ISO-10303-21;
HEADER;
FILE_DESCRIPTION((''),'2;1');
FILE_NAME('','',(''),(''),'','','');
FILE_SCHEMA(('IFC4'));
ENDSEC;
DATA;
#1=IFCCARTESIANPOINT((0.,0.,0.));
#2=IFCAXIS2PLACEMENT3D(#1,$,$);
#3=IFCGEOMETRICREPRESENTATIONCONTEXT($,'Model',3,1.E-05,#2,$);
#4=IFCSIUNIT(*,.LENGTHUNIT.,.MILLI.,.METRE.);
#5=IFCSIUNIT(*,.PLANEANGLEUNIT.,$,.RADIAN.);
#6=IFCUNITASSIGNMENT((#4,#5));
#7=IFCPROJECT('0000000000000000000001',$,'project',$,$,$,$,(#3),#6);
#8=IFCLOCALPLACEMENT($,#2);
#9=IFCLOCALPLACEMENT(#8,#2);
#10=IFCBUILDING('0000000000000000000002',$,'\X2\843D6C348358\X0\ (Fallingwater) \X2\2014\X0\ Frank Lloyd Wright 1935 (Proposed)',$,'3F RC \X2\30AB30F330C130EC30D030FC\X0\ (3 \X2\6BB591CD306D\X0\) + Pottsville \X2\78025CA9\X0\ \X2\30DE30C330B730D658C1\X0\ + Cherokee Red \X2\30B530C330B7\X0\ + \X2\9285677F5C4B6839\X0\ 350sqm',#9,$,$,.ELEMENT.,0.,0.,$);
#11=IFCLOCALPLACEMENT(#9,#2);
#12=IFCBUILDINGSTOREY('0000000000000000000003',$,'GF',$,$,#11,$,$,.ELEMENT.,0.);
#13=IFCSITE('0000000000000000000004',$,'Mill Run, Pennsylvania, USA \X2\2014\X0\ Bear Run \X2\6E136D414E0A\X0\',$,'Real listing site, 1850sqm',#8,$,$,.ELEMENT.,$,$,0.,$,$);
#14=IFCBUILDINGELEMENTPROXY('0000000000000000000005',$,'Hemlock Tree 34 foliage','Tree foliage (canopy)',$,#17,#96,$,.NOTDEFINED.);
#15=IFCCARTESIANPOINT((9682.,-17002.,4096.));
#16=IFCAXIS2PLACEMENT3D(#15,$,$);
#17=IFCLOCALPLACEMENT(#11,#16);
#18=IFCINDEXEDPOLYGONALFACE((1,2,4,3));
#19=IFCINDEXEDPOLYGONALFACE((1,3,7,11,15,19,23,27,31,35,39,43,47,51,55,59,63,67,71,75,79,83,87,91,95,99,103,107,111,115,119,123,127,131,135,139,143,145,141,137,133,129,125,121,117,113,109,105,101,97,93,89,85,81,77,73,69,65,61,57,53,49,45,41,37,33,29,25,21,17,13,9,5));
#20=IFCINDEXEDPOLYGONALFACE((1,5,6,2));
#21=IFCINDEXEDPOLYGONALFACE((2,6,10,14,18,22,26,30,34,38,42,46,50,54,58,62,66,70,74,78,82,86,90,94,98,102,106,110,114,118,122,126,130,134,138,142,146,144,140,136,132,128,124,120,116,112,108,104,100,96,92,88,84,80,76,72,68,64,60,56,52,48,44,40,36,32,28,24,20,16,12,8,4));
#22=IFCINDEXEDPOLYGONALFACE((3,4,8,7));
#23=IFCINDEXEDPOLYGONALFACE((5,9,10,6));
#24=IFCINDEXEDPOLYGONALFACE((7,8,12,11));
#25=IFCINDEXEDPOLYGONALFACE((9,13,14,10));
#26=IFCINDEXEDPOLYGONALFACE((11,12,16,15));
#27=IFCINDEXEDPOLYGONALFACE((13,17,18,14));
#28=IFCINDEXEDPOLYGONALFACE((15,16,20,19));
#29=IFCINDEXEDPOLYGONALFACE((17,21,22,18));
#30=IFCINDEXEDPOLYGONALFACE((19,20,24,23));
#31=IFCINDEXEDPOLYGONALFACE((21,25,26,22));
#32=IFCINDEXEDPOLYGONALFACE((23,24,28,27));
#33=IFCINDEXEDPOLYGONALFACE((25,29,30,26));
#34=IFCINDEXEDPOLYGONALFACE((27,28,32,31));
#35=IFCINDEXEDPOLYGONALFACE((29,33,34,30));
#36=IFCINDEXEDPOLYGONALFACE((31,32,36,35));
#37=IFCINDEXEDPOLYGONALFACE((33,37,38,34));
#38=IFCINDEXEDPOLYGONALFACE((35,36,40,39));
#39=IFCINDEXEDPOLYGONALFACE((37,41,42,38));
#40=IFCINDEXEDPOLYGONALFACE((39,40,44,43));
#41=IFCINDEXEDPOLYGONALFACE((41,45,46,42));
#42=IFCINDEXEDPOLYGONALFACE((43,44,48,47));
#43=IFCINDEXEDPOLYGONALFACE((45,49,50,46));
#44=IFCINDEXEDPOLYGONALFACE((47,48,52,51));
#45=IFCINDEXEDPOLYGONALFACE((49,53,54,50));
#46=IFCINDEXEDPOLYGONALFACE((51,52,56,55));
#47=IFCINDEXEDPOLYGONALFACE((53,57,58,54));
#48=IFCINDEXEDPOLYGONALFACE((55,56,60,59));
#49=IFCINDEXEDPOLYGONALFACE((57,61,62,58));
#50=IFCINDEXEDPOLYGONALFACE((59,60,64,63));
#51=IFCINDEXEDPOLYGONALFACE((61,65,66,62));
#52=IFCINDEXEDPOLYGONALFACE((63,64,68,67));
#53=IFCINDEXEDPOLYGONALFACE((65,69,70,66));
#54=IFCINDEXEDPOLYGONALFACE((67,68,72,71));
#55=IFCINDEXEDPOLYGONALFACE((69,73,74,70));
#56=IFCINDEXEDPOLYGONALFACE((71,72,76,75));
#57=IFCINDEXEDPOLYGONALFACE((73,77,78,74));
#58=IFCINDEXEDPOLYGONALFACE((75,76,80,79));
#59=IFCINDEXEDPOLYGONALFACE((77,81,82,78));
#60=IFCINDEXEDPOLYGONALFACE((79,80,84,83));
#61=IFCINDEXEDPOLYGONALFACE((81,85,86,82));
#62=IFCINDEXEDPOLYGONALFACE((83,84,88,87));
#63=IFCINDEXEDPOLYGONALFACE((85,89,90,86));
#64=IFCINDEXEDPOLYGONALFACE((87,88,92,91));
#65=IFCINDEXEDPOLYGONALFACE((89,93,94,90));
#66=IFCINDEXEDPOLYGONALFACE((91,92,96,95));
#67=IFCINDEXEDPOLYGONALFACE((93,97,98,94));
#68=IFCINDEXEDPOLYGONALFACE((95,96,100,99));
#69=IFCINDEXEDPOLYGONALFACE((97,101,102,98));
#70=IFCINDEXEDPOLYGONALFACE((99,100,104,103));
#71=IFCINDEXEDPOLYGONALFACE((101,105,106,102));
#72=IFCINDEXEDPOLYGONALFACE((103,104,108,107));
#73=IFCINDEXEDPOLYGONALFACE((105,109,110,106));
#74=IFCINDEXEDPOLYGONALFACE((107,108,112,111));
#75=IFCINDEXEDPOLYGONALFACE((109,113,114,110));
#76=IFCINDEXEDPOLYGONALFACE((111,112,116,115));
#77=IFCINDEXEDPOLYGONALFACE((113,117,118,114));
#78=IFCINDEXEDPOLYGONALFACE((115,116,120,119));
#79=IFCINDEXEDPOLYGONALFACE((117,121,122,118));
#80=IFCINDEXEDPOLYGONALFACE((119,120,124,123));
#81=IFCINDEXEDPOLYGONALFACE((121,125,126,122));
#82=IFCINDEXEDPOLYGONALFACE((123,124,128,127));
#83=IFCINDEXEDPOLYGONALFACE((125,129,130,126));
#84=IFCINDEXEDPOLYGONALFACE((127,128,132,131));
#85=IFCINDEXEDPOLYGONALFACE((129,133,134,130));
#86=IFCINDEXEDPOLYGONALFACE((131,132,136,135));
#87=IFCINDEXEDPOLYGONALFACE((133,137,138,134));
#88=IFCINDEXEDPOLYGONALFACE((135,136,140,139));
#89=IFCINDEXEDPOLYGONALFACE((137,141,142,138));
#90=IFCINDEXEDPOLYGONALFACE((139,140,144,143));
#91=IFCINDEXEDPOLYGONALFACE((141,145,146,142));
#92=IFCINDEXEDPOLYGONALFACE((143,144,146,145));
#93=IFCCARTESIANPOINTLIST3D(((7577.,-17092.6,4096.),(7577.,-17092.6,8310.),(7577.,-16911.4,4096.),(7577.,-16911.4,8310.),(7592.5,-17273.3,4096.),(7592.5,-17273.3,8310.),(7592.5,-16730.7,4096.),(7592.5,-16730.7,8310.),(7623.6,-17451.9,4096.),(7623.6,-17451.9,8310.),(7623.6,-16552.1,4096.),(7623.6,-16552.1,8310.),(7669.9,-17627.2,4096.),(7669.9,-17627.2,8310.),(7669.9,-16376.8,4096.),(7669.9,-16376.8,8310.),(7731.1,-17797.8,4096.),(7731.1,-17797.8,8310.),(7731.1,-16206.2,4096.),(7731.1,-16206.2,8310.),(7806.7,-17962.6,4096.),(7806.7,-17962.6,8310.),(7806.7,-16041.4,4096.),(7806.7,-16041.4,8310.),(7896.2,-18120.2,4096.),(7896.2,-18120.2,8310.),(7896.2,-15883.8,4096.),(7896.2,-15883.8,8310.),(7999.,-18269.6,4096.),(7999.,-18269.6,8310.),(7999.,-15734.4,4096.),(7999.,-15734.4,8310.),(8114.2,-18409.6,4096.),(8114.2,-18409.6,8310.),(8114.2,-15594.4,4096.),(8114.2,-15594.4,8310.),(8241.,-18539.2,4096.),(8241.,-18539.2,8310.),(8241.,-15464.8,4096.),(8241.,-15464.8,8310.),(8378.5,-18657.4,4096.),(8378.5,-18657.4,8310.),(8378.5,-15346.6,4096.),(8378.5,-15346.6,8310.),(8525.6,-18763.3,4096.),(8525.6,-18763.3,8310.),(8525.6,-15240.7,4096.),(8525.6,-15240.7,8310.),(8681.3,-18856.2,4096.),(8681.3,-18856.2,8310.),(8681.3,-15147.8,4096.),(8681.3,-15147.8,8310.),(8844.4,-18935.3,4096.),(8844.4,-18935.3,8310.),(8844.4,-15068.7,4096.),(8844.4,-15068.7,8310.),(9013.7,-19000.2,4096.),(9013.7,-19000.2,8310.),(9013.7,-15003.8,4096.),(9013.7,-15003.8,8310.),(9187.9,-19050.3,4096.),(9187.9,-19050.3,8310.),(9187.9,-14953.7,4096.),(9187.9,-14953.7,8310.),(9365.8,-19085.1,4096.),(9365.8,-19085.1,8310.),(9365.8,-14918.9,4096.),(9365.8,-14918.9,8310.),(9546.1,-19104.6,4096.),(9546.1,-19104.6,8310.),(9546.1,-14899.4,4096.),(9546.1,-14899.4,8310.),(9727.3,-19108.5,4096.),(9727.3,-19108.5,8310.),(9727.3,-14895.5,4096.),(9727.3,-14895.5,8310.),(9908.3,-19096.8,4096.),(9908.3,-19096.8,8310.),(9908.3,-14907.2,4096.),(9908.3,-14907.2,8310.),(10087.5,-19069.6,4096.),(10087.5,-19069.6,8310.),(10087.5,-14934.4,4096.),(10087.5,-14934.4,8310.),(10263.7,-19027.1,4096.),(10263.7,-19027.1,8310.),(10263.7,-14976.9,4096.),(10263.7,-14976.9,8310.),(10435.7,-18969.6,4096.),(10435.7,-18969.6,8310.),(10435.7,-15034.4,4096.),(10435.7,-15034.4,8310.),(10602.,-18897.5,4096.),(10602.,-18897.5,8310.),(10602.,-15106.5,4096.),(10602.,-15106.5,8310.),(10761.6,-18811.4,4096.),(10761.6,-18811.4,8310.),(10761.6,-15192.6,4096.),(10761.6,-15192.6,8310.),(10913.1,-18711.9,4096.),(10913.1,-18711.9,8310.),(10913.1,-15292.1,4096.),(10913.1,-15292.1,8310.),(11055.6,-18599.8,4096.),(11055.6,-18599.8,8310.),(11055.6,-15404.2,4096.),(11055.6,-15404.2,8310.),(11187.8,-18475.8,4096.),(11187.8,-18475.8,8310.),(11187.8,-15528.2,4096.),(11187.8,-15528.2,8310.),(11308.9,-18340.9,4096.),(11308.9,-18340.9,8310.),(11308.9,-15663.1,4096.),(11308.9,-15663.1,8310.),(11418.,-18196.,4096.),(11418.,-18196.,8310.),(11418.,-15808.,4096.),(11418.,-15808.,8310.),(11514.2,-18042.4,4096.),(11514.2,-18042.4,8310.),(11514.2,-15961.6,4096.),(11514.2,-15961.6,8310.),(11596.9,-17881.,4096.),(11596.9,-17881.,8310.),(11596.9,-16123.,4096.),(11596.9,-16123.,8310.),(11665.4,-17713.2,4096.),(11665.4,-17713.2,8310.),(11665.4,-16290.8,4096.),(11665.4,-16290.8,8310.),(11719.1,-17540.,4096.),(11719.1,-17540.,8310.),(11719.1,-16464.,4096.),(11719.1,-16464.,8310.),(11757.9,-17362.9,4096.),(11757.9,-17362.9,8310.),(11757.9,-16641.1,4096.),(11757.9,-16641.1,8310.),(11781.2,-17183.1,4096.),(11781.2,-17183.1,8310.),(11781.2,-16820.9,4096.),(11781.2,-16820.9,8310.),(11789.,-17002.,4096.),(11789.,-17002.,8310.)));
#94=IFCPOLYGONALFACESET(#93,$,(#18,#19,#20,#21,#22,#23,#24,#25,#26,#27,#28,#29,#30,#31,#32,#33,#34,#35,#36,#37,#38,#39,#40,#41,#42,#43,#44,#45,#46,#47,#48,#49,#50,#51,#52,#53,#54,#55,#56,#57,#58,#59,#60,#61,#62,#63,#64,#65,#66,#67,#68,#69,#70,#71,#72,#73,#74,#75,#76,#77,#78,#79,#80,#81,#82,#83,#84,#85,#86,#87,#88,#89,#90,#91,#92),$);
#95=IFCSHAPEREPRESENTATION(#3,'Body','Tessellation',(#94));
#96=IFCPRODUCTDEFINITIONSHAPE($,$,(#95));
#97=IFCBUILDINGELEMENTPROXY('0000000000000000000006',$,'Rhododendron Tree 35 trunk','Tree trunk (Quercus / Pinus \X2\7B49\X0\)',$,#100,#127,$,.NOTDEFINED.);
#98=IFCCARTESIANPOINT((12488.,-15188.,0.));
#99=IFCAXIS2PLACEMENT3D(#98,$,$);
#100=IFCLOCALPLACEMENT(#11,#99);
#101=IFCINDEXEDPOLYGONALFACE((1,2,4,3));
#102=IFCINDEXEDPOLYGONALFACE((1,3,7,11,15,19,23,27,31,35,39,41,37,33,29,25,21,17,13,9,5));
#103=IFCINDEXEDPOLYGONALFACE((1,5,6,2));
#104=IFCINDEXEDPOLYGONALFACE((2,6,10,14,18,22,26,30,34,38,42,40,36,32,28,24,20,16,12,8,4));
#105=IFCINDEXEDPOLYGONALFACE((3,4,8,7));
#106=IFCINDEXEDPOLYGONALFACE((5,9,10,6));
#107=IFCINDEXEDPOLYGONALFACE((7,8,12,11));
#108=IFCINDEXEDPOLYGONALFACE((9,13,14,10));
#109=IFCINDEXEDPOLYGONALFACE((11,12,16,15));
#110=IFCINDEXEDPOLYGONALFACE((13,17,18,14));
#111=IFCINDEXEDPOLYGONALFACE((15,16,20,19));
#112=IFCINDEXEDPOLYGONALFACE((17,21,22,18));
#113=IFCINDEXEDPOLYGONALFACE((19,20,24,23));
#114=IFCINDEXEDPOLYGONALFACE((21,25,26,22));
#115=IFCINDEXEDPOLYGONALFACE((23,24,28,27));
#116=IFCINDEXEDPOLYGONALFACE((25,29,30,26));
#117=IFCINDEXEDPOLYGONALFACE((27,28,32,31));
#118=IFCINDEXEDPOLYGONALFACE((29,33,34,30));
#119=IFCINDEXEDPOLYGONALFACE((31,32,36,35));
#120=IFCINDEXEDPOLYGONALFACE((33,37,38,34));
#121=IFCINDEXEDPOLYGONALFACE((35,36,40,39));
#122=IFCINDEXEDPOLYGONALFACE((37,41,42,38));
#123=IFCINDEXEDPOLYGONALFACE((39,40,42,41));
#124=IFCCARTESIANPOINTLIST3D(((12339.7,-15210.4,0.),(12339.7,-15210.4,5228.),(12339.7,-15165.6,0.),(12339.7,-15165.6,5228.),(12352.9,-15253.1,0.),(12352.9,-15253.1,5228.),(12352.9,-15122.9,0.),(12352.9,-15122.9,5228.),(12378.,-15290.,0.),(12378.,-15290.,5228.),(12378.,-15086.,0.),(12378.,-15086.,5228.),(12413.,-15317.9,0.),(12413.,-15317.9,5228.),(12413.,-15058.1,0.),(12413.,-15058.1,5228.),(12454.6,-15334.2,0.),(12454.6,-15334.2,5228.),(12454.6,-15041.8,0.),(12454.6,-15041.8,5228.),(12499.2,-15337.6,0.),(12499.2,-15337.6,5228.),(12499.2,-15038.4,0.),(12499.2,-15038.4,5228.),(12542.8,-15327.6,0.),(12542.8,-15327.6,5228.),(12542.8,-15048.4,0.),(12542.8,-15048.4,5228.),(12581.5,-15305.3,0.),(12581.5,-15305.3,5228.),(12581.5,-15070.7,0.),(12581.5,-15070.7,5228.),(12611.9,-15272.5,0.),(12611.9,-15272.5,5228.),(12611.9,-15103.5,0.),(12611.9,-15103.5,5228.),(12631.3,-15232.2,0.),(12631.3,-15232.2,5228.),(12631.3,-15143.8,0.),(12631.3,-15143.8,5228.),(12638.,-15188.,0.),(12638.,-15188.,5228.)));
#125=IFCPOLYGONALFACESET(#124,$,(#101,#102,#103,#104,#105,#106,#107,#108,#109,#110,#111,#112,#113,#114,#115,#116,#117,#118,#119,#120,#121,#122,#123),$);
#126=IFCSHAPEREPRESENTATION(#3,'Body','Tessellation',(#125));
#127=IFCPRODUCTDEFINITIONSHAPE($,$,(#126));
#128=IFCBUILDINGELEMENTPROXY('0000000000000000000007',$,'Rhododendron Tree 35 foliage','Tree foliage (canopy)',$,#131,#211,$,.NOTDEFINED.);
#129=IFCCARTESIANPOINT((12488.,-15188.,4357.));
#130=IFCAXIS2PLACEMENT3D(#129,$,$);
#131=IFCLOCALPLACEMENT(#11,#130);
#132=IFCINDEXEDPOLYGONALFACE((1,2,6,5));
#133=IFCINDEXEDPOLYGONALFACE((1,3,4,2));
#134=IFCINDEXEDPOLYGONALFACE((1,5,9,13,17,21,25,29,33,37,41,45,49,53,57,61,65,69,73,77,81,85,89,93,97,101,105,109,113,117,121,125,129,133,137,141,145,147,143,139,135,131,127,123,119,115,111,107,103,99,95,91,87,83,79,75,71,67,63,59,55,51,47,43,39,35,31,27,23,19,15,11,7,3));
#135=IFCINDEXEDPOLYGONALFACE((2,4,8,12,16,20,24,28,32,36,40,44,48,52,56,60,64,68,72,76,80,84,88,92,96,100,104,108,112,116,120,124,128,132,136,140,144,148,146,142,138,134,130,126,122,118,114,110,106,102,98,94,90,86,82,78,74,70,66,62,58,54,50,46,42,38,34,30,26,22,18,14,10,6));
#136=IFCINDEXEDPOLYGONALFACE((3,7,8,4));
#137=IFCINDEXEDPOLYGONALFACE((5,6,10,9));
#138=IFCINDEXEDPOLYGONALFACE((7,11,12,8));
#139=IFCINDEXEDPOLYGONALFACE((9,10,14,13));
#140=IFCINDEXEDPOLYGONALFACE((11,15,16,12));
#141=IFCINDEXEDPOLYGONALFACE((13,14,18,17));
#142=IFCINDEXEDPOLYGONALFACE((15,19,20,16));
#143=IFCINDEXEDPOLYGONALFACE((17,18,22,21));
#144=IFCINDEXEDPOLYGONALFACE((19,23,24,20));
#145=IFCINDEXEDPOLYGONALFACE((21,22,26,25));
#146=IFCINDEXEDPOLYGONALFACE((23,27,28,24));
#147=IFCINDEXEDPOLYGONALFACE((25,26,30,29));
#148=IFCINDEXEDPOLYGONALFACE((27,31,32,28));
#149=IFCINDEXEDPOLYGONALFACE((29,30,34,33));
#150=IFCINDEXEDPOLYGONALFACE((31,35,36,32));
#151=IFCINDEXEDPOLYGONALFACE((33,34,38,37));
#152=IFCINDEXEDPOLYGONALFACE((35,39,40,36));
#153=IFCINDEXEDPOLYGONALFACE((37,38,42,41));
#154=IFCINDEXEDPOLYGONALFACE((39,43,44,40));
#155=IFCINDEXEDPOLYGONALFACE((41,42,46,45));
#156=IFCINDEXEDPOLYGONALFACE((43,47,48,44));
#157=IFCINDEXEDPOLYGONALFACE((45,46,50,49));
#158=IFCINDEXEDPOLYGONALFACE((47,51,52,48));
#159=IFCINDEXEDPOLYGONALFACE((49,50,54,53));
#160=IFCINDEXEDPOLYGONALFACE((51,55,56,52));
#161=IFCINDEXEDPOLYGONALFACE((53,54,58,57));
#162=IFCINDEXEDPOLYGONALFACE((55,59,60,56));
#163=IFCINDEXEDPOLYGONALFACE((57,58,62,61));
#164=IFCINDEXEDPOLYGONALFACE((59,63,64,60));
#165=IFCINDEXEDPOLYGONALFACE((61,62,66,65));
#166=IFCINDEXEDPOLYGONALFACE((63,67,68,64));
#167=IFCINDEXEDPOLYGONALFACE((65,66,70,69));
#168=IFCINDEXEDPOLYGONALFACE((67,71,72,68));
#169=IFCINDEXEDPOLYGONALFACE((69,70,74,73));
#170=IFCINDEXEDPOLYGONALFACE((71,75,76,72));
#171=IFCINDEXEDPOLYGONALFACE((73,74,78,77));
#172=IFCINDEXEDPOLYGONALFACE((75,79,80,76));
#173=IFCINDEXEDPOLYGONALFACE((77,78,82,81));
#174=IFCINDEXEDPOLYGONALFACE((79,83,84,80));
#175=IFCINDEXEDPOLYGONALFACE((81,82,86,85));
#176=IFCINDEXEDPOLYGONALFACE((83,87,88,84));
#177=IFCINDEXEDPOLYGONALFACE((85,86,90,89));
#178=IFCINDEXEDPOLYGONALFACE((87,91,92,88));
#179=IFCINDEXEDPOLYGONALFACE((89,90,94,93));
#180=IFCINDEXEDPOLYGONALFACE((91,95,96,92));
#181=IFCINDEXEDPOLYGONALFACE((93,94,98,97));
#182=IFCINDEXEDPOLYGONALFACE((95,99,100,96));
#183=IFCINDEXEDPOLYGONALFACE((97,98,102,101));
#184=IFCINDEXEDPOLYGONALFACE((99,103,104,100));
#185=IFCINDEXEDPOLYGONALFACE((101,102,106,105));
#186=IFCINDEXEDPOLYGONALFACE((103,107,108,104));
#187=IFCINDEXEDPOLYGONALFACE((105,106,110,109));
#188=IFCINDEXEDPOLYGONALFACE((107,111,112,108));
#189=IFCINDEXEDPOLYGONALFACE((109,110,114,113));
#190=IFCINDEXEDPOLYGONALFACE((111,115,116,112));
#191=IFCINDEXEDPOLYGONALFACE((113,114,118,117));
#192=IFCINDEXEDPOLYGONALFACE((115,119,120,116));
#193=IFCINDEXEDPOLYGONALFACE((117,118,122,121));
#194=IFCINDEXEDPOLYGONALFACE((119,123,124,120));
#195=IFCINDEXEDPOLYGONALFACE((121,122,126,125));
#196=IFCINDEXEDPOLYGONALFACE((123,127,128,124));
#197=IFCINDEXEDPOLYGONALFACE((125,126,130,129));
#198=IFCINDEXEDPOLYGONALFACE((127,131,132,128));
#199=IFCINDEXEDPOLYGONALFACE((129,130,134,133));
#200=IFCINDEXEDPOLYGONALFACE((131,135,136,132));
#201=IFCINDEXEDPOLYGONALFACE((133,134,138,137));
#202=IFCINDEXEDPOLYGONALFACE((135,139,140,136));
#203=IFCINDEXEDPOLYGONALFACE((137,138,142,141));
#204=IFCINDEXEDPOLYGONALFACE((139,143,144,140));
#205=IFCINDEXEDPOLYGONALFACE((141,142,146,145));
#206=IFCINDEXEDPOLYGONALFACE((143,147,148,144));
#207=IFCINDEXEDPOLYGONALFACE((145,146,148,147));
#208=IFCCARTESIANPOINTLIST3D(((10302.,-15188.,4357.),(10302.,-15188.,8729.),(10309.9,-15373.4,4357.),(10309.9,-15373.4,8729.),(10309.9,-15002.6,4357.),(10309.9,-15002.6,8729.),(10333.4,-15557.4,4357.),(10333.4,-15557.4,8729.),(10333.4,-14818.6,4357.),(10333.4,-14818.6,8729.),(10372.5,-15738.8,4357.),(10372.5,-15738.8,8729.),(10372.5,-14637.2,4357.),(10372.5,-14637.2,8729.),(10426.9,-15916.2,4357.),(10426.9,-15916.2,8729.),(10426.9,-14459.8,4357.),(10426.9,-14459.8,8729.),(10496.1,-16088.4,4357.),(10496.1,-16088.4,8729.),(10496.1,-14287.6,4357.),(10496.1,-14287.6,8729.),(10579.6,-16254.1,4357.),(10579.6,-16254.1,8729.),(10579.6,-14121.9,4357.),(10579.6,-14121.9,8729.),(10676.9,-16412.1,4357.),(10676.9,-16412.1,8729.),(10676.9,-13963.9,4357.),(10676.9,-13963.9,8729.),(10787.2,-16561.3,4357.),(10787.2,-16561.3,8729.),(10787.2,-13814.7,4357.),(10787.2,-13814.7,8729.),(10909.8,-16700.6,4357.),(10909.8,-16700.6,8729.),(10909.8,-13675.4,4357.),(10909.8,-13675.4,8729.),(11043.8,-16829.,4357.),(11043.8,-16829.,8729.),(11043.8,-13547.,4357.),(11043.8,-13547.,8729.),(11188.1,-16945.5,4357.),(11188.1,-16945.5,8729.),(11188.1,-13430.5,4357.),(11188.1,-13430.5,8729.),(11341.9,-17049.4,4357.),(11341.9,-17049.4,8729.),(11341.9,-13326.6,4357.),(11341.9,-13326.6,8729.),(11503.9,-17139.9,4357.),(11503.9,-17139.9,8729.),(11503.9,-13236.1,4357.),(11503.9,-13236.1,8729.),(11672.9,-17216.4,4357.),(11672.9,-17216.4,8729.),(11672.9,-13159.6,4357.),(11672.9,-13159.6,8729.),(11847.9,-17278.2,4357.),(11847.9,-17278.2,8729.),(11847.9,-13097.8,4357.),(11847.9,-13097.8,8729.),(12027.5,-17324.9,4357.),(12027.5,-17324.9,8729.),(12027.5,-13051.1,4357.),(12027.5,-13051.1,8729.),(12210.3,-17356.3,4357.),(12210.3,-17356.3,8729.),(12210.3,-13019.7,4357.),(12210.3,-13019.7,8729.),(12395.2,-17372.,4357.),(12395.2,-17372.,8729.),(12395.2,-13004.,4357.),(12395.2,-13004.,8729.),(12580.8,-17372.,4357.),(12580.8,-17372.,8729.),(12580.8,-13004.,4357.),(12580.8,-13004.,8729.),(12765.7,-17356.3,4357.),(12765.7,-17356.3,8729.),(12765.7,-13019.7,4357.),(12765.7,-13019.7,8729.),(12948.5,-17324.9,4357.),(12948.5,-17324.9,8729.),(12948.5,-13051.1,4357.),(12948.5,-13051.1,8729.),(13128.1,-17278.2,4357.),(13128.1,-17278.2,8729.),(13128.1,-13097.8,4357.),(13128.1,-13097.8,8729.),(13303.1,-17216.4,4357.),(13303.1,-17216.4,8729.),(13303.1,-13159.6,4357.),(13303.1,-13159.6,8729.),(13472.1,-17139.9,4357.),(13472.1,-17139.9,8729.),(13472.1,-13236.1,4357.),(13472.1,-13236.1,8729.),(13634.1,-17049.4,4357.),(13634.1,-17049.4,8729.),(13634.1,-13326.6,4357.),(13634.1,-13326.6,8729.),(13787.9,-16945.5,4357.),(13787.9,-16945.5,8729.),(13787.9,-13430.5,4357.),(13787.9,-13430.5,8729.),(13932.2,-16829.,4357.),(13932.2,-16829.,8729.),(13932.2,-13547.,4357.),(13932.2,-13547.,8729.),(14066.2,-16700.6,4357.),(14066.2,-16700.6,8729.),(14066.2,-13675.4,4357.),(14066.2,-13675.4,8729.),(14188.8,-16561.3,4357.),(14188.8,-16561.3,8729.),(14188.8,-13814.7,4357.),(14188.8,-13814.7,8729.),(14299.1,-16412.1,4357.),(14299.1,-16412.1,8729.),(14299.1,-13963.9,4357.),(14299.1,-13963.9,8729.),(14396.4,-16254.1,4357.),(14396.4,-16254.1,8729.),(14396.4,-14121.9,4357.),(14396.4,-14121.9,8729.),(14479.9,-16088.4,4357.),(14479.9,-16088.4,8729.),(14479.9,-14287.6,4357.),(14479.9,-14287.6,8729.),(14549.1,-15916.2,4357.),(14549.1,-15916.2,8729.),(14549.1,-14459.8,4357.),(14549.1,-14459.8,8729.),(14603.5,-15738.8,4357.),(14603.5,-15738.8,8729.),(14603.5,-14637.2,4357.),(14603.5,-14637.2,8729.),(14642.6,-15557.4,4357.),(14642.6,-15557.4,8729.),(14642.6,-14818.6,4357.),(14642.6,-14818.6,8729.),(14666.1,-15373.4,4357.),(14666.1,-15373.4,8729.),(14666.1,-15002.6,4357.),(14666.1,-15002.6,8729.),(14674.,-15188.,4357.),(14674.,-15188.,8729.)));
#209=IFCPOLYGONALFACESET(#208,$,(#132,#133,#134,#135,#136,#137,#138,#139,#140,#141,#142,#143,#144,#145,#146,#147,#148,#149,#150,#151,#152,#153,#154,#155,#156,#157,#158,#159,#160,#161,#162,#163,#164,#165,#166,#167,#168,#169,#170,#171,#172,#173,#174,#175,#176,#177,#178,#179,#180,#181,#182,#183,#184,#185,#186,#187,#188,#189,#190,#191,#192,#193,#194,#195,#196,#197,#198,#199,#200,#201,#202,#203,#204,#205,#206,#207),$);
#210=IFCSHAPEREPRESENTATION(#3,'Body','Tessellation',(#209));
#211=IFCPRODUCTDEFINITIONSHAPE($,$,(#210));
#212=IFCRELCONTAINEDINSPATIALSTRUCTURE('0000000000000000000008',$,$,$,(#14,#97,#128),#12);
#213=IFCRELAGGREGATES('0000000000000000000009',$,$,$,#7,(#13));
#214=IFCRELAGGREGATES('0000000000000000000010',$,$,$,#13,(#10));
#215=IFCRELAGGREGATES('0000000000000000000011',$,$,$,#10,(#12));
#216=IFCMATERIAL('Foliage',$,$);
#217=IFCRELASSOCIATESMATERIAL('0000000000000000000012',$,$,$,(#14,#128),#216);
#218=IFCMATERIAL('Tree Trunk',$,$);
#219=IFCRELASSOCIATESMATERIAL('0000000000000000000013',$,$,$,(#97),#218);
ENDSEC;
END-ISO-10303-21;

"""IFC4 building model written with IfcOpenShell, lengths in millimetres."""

from ifc_helpers import new_model, si_unit, frame, origin, origin_2d, place, context, project, spatial, circle, extrude, material, element, save


model = new_model("IFC4")

# Units and contexts
model_context = context("Model", 3, precision=1e-05, world=origin())
ifc_project = project(units=[si_unit("LENGTHUNIT", "METRE", prefix="MILLI"), si_unit("PLANEANGLEUNIT", "RADIAN")], contexts=[model_context])

# Site, building, storey
site_placement = place(None, origin())
site = spatial("IfcSite", under=ifc_project, at=site_placement, Name="Mill Run, Pennsylvania, USA — Bear Run 渓流上", ObjectType="Real listing site, 1850sqm", CompositionType="ELEMENT", RefElevation=0.0)
building_placement = place(site_placement, origin())
building = spatial("IfcBuilding", under=site, at=building_placement, Name="落水荘 (Fallingwater) — Frank Lloyd Wright 1935 (Proposed)", ObjectType="3F RC カンチレバー (3 段重ね) + Pottsville 砂岩 マッシブ壁 + Cherokee Red サッシ + 銅板屋根 350sqm", CompositionType="ELEMENT", ElevationOfRefHeight=0.0, ElevationOfTerrain=0.0)
storey_placement = place(building_placement, origin())
storey = spatial("IfcBuildingStorey", under=building, at=storey_placement, Name="GF", CompositionType="ELEMENT", Elevation=0.0)

# Building element proxies
ifc_material_1 = material(Name="Tree Trunk")
ifc_material_2 = material(Name="Foliage")
proxy_1_placement = place(storey_placement, frame((9682.0, -17002.0, 4096.0)))
element("IfcBuildingElementProxy", 1, at=proxy_1_placement, inside=storey, material=ifc_material_2, Name="Hemlock Tree 34 foliage", Description="Tree foliage (canopy)", PredefinedType="NOTDEFINED", context=model_context, shape_type="SweptSolid", body=[
    extrude(circle(Radius=2107.0, at=origin_2d()), frame((9682.0, -17002.0, 4096.0)), (0.0, 0.0, 1.0), 4214.0),
])
proxy_2_placement = place(storey_placement, frame((12488.0, -15188.0, 0.0)))
element("IfcBuildingElementProxy", 2, at=proxy_2_placement, inside=storey, material=ifc_material_1, Name="Rhododendron Tree 35 trunk", Description="Tree trunk (Quercus / Pinus 等)", PredefinedType="NOTDEFINED", context=model_context, shape_type="SweptSolid", body=[
    extrude(circle(Radius=150.0, at=origin_2d()), frame((12488.0, -15188.0, 0.0)), (0.0, 0.0, 1.0), 5228.0),
])
proxy_3_placement = place(storey_placement, frame((12488.0, -15188.0, 4357.0)))
element("IfcBuildingElementProxy", 3, at=proxy_3_placement, inside=storey, material=ifc_material_2, Name="Rhododendron Tree 35 foliage", Description="Tree foliage (canopy)", PredefinedType="NOTDEFINED", context=model_context, shape_type="SweptSolid", body=[
    extrude(circle(Radius=2186.0, at=origin_2d()), frame((12488.0, -15188.0, 4357.0)), (0.0, 0.0, 1.0), 4372.0),
])

save(model, "model.ifc")
